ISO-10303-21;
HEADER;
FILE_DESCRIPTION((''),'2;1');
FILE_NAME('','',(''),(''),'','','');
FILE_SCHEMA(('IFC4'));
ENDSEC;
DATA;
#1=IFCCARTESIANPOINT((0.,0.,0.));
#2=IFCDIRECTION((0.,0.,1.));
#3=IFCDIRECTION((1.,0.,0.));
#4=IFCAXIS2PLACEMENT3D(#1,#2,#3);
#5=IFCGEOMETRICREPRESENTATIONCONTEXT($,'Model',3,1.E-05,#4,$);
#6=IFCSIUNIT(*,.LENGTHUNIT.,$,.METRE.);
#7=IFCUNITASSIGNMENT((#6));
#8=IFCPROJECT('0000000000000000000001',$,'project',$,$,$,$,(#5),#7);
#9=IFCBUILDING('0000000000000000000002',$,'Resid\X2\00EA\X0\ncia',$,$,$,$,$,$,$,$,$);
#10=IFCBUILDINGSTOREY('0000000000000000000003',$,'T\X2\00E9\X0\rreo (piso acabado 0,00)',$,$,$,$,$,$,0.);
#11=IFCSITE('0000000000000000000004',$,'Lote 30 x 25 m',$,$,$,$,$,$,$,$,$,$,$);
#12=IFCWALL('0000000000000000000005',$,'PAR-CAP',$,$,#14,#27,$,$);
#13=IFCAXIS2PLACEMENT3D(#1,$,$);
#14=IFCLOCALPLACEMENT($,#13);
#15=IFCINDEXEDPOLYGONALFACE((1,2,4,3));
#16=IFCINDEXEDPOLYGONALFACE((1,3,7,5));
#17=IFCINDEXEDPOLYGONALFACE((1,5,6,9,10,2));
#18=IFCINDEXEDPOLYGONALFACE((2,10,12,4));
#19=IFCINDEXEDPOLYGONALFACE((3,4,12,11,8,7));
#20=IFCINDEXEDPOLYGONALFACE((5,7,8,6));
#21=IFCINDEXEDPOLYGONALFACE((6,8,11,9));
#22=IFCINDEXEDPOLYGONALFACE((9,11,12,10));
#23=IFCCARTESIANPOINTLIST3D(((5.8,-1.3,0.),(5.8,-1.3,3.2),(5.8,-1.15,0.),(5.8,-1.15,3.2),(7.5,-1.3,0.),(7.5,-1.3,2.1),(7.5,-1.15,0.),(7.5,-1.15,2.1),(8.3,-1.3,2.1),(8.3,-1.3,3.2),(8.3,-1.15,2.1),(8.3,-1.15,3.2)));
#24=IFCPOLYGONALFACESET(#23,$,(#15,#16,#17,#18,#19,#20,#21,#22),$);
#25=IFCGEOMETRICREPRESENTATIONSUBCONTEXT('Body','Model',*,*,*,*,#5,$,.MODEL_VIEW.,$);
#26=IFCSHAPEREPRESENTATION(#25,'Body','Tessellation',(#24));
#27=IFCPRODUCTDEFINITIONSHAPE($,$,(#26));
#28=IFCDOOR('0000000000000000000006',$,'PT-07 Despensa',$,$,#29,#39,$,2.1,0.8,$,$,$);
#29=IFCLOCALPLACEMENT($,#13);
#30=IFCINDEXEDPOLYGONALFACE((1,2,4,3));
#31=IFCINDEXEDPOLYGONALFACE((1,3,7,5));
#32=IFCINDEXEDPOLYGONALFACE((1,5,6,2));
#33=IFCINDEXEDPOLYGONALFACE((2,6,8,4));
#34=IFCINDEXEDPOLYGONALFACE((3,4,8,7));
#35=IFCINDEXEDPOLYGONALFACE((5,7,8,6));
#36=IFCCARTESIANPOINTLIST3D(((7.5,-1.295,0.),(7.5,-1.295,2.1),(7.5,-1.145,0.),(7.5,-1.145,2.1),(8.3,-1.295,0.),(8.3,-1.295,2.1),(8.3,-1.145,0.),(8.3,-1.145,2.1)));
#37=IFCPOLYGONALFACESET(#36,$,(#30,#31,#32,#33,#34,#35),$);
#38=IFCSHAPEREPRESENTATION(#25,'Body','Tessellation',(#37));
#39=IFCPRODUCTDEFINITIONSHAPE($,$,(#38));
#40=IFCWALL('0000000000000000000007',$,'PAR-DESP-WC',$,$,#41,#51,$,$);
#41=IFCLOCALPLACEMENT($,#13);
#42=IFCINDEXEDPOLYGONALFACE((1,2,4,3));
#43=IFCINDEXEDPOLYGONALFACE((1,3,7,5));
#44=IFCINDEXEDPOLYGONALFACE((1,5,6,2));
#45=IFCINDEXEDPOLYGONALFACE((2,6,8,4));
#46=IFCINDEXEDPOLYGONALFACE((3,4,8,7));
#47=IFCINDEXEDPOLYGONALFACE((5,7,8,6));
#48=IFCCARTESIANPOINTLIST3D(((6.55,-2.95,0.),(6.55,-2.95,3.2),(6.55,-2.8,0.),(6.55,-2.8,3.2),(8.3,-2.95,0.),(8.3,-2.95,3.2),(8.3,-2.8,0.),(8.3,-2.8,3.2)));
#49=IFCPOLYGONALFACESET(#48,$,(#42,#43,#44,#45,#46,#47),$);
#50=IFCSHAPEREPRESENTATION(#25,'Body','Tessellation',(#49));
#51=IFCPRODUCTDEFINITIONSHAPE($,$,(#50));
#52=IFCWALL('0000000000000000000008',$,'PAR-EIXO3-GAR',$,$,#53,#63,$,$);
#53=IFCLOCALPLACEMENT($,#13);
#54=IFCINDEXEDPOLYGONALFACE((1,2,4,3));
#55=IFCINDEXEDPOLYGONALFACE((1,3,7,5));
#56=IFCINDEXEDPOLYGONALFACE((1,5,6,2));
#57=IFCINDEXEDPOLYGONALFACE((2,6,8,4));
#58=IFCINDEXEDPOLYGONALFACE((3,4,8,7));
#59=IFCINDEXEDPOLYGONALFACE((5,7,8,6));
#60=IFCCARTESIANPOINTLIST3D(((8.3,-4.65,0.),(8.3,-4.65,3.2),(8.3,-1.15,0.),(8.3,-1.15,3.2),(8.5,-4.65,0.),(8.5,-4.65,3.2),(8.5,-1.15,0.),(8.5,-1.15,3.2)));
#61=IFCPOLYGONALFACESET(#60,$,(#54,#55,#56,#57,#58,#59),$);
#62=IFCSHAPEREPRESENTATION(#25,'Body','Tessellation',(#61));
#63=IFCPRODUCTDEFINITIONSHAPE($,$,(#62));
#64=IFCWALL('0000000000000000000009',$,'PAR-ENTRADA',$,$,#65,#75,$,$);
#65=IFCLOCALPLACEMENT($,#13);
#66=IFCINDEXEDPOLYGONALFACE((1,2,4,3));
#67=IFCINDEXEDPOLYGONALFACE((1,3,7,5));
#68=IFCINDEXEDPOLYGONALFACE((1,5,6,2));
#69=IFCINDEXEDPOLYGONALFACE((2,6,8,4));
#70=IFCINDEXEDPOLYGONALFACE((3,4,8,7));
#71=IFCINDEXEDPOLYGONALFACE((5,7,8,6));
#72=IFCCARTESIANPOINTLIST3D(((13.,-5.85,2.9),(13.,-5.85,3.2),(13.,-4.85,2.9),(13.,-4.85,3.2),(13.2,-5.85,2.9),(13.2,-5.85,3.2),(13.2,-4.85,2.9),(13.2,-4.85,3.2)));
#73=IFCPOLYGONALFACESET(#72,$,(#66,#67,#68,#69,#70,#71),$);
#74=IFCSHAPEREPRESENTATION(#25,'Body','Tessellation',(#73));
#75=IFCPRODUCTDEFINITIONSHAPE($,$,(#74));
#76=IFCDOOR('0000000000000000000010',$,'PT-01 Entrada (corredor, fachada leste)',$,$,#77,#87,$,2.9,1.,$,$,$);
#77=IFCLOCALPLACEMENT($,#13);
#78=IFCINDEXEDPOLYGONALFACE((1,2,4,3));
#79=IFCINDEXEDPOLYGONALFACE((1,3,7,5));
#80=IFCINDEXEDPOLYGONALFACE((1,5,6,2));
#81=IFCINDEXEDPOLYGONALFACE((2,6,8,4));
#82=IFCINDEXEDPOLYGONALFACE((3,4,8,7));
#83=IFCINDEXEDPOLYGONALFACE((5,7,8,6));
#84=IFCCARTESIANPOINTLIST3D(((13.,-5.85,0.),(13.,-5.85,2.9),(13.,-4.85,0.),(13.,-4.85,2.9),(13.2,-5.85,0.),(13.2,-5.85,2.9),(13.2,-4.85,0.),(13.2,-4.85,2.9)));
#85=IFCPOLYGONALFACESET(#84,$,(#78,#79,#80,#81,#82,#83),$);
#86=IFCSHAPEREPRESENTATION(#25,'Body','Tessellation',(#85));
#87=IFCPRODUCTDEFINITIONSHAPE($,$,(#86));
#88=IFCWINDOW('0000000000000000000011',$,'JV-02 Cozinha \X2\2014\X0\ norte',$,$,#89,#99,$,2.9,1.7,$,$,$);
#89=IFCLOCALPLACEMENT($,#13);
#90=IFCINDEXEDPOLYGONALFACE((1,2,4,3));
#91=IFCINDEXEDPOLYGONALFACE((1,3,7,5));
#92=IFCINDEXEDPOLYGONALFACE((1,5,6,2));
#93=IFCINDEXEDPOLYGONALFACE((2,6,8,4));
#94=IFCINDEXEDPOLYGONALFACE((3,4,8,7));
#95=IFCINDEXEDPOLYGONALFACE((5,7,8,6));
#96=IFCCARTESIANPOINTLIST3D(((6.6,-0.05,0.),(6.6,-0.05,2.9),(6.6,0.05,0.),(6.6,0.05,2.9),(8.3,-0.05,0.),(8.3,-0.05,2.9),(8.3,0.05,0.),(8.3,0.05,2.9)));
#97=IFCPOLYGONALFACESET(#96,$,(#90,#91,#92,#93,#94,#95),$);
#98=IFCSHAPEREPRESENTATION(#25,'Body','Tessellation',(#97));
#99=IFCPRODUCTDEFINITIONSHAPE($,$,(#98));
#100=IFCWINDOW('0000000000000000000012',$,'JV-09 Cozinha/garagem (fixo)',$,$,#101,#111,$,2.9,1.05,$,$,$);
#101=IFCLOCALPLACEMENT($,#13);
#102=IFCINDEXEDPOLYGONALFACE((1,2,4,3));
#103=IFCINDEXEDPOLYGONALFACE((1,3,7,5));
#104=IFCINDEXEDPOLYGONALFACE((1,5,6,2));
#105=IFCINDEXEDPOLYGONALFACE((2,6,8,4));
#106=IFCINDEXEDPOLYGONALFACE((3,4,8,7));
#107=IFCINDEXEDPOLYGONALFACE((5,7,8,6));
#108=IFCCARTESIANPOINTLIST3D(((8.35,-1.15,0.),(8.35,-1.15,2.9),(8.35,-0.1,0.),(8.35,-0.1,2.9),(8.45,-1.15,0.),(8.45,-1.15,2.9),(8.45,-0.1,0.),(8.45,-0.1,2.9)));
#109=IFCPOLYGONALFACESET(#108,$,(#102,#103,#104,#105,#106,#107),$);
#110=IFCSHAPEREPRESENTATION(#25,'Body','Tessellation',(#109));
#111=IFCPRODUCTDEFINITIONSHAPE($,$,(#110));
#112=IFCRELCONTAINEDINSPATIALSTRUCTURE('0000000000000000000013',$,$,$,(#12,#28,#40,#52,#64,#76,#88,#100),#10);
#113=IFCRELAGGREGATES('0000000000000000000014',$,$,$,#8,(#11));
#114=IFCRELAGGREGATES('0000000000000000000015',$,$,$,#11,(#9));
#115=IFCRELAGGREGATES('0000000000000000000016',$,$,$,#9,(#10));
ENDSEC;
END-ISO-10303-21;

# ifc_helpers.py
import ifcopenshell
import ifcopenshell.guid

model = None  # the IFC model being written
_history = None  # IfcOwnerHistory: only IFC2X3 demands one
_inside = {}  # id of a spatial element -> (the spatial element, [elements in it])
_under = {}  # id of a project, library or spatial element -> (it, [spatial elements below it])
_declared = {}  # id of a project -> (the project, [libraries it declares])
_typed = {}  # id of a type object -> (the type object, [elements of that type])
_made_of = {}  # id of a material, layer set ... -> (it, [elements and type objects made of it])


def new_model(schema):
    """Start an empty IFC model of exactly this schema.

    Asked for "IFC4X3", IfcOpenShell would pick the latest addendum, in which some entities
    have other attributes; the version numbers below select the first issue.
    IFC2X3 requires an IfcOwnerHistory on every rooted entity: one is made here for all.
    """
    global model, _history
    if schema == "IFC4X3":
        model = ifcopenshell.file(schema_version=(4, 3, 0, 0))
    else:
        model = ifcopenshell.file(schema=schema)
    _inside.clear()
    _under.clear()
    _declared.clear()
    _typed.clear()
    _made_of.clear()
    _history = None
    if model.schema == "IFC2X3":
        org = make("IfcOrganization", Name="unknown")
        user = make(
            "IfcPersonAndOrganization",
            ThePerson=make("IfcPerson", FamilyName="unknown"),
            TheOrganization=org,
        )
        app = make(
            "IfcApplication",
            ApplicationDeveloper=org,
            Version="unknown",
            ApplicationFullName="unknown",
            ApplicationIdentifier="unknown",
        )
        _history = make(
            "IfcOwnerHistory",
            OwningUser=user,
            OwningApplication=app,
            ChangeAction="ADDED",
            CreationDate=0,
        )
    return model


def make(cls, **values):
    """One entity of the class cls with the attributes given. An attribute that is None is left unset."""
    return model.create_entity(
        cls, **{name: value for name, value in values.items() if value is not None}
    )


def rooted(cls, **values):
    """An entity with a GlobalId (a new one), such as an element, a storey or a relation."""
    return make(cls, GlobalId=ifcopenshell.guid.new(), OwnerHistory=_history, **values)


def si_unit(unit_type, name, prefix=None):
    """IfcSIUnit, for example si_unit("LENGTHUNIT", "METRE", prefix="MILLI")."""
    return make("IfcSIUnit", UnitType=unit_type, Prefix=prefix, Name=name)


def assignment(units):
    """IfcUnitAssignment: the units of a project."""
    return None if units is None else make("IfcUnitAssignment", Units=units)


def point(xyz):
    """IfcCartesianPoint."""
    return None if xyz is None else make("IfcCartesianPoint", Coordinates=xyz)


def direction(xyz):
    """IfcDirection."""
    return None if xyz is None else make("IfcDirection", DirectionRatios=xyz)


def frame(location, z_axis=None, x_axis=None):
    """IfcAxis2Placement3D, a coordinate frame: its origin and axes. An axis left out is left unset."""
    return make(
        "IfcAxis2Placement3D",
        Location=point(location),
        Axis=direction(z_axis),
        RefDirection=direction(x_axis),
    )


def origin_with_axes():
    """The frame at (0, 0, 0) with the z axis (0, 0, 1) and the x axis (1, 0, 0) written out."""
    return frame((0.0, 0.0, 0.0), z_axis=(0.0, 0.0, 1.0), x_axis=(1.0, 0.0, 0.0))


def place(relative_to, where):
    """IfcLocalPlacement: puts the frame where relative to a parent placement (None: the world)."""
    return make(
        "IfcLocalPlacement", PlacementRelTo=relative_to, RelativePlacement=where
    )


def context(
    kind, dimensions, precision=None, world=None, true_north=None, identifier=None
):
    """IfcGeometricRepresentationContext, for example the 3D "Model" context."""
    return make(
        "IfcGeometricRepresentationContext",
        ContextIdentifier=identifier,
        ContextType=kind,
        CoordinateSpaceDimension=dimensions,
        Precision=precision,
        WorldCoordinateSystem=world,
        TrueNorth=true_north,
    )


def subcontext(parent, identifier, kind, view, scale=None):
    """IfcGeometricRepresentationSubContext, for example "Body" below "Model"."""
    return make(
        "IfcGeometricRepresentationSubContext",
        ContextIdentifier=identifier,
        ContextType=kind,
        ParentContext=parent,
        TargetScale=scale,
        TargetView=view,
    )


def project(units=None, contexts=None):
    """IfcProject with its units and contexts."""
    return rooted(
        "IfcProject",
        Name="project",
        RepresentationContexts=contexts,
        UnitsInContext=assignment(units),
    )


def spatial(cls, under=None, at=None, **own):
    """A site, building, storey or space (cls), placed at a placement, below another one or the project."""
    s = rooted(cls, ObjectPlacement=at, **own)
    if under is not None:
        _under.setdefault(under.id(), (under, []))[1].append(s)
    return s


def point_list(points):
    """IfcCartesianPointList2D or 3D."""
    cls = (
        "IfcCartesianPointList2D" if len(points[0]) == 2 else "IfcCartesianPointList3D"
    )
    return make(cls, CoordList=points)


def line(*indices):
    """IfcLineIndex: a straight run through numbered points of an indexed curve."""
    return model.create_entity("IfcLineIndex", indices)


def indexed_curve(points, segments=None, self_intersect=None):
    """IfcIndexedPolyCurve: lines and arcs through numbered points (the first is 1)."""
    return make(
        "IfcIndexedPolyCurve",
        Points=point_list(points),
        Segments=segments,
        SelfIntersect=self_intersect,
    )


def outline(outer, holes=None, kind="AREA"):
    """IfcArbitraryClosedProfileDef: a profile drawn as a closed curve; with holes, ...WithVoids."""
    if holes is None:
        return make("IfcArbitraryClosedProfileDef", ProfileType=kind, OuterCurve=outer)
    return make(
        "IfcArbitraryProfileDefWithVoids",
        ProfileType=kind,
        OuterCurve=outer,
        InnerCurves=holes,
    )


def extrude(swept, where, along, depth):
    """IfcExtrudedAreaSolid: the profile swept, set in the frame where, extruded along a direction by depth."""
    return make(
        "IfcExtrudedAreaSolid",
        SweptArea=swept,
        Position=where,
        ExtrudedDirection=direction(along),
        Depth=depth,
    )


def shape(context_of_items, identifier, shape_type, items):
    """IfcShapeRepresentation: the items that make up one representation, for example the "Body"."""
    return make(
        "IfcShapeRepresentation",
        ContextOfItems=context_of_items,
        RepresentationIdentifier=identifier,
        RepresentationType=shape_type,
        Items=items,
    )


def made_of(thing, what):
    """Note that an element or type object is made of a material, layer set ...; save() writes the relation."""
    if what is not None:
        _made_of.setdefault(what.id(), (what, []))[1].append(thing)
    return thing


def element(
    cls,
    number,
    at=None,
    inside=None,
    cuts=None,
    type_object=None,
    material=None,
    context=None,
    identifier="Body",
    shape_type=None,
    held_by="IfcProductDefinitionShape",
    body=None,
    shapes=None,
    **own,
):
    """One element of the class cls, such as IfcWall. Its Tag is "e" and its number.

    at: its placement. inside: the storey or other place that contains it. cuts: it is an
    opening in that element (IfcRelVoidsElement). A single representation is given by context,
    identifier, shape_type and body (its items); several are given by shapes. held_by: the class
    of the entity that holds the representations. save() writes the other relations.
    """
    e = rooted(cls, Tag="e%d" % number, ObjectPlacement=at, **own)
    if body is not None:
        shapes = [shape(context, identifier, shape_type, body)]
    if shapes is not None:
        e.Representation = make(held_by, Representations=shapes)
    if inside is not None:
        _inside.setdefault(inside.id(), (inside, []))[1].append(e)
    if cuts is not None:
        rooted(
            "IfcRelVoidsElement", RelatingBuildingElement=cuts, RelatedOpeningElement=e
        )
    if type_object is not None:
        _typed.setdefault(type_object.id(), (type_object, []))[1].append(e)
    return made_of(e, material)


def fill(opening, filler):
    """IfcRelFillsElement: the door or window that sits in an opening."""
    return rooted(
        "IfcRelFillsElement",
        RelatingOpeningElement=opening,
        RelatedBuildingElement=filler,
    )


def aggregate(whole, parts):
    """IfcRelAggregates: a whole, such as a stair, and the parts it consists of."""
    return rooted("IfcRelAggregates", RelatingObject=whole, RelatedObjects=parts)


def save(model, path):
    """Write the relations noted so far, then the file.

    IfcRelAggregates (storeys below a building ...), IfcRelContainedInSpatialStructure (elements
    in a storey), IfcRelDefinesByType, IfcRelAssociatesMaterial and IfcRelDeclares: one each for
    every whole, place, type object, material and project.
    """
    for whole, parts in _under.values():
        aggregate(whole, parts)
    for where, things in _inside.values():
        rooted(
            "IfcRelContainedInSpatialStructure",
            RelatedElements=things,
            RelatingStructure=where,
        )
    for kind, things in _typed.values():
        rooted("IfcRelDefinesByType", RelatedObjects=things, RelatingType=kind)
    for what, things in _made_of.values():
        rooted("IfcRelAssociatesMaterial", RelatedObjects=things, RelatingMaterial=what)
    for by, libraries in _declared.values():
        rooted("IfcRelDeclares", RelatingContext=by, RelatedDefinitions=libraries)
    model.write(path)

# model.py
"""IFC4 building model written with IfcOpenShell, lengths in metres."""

from ifc_helpers import new_model, si_unit, frame, origin_with_axes, place, context, subcontext, project, spatial, line, indexed_curve, outline, extrude, element, fill, save


model = new_model("IFC4")

# Units and contexts
model_context = context("Model", 3, precision=1e-05, world=origin_with_axes())
body_context = subcontext(model_context, "Body", "Model", "MODEL_VIEW")
ifc_project = project(units=[si_unit("LENGTHUNIT", "METRE")], contexts=[model_context])

# Site, building, storey
site = spatial("IfcSite", under=ifc_project, Name="Lote 30 x 25 m")
building = spatial("IfcBuilding", under=site, Name="Residência")
storey = spatial("IfcBuildingStorey", under=building, Name="Térreo (piso acabado 0,00)", Elevation=0.0)

# Wall, opening, door
wall_1_placement = place(None, frame((5.8, -1.3, 0.0), z_axis=(0.0, 0.0, 1.0), x_axis=(1.0, 0.0, 0.0)))
wall_1 = element("IfcWall", 1, at=wall_1_placement, inside=storey, Name="PAR-CAP", context=body_context, shape_type="SweptSolid", body=[
    extrude(outline(indexed_curve([(0.0, 0.0), (2.5, 0.0), (2.5, 0.15), (0.0, 0.15)], segments=[line(1, 2, 3, 4, 1)])), origin_with_axes(), (0.0, 0.0, 1.0), 3.2),
])
opening_1_placement = place(wall_1_placement, frame((1.7, -0.005, 0.0), z_axis=(0.0, 0.0, 1.0), x_axis=(1.0, 0.0, 0.0)))
opening_1 = element("IfcOpeningElement", 2, at=opening_1_placement, cuts=wall_1, context=body_context, shape_type="SweptSolid", body=[
    extrude(outline(indexed_curve([(0.0, 0.0), (0.8, 0.0), (0.8, 0.17), (0.0, 0.17)], segments=[line(1, 2, 3, 4, 1)])), origin_with_axes(), (0.0, 0.0, 1.0), 2.1),
])
door_1_placement = place(None, frame((7.5, -1.295, 0.0), z_axis=(0.0, 0.0, 1.0), x_axis=(1.0, 0.0, 0.0)))
door_1 = element("IfcDoor", 3, at=door_1_placement, inside=storey, Name="PT-07 Despensa", OverallHeight=2.1, OverallWidth=0.8, context=body_context, shape_type="SweptSolid", body=[
    extrude(outline(indexed_curve([(0.0, 0.0), (0.8, 0.0), (0.8, 0.15), (0.0, 0.15)], segments=[line(1, 2, 3, 4, 1)])), origin_with_axes(), (0.0, 0.0, 1.0), 2.1),
])
fill(opening_1, door_1)

# Walls
wall_2_placement = place(None, frame((6.55, -2.95, 0.0), z_axis=(0.0, 0.0, 1.0), x_axis=(1.0, 0.0, 0.0)))
element("IfcWall", 4, at=wall_2_placement, inside=storey, Name="PAR-DESP-WC", context=body_context, shape_type="SweptSolid", body=[
    extrude(outline(indexed_curve([(0.0, 0.0), (1.75, 0.0), (1.75, 0.15), (0.0, 0.15)], segments=[line(1, 2, 3, 4, 1)])), origin_with_axes(), (0.0, 0.0, 1.0), 3.2),
])
wall_3_placement = place(None, frame((8.3, -4.65, 0.0), z_axis=(0.0, 0.0, 1.0), x_axis=(1.0, 0.0, 0.0)))
element("IfcWall", 5, at=wall_3_placement, inside=storey, Name="PAR-EIXO3-GAR", context=body_context, shape_type="SweptSolid", body=[
    extrude(outline(indexed_curve([(0.0, 0.0), (0.2, 0.0), (0.2, 3.5), (0.0, 3.5)], segments=[line(1, 2, 3, 4, 1)])), origin_with_axes(), (0.0, 0.0, 1.0), 3.2),
])

# Wall, opening, door
wall_4_placement = place(None, frame((13.0, -5.85, 0.0), z_axis=(0.0, 0.0, 1.0), x_axis=(1.0, 0.0, 0.0)))
wall_4 = element("IfcWall", 6, at=wall_4_placement, inside=storey, Name="PAR-ENTRADA", context=body_context, shape_type="SweptSolid", body=[
    extrude(outline(indexed_curve([(0.0, 0.0), (0.2, 0.0), (0.2, 1.0), (0.0, 1.0)], segments=[line(1, 2, 3, 4, 1)])), origin_with_axes(), (0.0, 0.0, 1.0), 3.2),
])
opening_2_placement = place(wall_4_placement, origin_with_axes())
opening_2 = element("IfcOpeningElement", 7, at=opening_2_placement, cuts=wall_4, context=body_context, shape_type="SweptSolid", body=[
    extrude(outline(indexed_curve([(0.0, 0.0), (0.2, 0.0), (0.2, 1.0), (0.0, 1.0)], segments=[line(1, 2, 3, 4, 1)])), origin_with_axes(), (0.0, 0.0, 1.0), 2.9),
])
door_2_placement = place(None, frame((13.0, -5.85, 0.0), z_axis=(0.0, 0.0, 1.0), x_axis=(1.0, 0.0, 0.0)))
door_2 = element("IfcDoor", 8, at=door_2_placement, inside=storey, Name="PT-01 Entrada (corredor, fachada leste)", OverallHeight=2.9, OverallWidth=1.0, context=body_context, shape_type="SweptSolid", body=[
    extrude(outline(indexed_curve([(0.0, 0.0), (0.2, 0.0), (0.2, 1.0), (0.0, 1.0)], segments=[line(1, 2, 3, 4, 1)])), origin_with_axes(), (0.0, 0.0, 1.0), 2.9),
])
fill(opening_2, door_2)

# Windows
window_1_placement = place(None, frame((6.6, -0.05, 0.0), z_axis=(0.0, 0.0, 1.0), x_axis=(1.0, 0.0, 0.0)))
element("IfcWindow", 9, at=window_1_placement, inside=storey, Name="JV-02 Cozinha — norte", OverallHeight=2.9, OverallWidth=1.7, context=body_context, shape_type="SweptSolid", body=[
    extrude(outline(indexed_curve([(0.0, 0.0), (1.7, 0.0), (1.7, 0.1), (0.0, 0.1)], segments=[line(1, 2, 3, 4, 1)])), origin_with_axes(), (0.0, 0.0, 1.0), 2.9),
])
window_2_placement = place(None, frame((8.35, -1.15, 0.0), z_axis=(0.0, 0.0, 1.0), x_axis=(1.0, 0.0, 0.0)))
element("IfcWindow", 10, at=window_2_placement, inside=storey, Name="JV-09 Cozinha/garagem (fixo)", OverallHeight=2.9, OverallWidth=1.05, context=body_context, shape_type="SweptSolid", body=[
    extrude(outline(indexed_curve([(0.0, 0.0), (0.1, 0.0), (0.1, 1.05), (0.0, 1.05)], segments=[line(1, 2, 3, 4, 1)])), origin_with_axes(), (0.0, 0.0, 1.0), 2.9),
])

save(model, "model.ifc")
